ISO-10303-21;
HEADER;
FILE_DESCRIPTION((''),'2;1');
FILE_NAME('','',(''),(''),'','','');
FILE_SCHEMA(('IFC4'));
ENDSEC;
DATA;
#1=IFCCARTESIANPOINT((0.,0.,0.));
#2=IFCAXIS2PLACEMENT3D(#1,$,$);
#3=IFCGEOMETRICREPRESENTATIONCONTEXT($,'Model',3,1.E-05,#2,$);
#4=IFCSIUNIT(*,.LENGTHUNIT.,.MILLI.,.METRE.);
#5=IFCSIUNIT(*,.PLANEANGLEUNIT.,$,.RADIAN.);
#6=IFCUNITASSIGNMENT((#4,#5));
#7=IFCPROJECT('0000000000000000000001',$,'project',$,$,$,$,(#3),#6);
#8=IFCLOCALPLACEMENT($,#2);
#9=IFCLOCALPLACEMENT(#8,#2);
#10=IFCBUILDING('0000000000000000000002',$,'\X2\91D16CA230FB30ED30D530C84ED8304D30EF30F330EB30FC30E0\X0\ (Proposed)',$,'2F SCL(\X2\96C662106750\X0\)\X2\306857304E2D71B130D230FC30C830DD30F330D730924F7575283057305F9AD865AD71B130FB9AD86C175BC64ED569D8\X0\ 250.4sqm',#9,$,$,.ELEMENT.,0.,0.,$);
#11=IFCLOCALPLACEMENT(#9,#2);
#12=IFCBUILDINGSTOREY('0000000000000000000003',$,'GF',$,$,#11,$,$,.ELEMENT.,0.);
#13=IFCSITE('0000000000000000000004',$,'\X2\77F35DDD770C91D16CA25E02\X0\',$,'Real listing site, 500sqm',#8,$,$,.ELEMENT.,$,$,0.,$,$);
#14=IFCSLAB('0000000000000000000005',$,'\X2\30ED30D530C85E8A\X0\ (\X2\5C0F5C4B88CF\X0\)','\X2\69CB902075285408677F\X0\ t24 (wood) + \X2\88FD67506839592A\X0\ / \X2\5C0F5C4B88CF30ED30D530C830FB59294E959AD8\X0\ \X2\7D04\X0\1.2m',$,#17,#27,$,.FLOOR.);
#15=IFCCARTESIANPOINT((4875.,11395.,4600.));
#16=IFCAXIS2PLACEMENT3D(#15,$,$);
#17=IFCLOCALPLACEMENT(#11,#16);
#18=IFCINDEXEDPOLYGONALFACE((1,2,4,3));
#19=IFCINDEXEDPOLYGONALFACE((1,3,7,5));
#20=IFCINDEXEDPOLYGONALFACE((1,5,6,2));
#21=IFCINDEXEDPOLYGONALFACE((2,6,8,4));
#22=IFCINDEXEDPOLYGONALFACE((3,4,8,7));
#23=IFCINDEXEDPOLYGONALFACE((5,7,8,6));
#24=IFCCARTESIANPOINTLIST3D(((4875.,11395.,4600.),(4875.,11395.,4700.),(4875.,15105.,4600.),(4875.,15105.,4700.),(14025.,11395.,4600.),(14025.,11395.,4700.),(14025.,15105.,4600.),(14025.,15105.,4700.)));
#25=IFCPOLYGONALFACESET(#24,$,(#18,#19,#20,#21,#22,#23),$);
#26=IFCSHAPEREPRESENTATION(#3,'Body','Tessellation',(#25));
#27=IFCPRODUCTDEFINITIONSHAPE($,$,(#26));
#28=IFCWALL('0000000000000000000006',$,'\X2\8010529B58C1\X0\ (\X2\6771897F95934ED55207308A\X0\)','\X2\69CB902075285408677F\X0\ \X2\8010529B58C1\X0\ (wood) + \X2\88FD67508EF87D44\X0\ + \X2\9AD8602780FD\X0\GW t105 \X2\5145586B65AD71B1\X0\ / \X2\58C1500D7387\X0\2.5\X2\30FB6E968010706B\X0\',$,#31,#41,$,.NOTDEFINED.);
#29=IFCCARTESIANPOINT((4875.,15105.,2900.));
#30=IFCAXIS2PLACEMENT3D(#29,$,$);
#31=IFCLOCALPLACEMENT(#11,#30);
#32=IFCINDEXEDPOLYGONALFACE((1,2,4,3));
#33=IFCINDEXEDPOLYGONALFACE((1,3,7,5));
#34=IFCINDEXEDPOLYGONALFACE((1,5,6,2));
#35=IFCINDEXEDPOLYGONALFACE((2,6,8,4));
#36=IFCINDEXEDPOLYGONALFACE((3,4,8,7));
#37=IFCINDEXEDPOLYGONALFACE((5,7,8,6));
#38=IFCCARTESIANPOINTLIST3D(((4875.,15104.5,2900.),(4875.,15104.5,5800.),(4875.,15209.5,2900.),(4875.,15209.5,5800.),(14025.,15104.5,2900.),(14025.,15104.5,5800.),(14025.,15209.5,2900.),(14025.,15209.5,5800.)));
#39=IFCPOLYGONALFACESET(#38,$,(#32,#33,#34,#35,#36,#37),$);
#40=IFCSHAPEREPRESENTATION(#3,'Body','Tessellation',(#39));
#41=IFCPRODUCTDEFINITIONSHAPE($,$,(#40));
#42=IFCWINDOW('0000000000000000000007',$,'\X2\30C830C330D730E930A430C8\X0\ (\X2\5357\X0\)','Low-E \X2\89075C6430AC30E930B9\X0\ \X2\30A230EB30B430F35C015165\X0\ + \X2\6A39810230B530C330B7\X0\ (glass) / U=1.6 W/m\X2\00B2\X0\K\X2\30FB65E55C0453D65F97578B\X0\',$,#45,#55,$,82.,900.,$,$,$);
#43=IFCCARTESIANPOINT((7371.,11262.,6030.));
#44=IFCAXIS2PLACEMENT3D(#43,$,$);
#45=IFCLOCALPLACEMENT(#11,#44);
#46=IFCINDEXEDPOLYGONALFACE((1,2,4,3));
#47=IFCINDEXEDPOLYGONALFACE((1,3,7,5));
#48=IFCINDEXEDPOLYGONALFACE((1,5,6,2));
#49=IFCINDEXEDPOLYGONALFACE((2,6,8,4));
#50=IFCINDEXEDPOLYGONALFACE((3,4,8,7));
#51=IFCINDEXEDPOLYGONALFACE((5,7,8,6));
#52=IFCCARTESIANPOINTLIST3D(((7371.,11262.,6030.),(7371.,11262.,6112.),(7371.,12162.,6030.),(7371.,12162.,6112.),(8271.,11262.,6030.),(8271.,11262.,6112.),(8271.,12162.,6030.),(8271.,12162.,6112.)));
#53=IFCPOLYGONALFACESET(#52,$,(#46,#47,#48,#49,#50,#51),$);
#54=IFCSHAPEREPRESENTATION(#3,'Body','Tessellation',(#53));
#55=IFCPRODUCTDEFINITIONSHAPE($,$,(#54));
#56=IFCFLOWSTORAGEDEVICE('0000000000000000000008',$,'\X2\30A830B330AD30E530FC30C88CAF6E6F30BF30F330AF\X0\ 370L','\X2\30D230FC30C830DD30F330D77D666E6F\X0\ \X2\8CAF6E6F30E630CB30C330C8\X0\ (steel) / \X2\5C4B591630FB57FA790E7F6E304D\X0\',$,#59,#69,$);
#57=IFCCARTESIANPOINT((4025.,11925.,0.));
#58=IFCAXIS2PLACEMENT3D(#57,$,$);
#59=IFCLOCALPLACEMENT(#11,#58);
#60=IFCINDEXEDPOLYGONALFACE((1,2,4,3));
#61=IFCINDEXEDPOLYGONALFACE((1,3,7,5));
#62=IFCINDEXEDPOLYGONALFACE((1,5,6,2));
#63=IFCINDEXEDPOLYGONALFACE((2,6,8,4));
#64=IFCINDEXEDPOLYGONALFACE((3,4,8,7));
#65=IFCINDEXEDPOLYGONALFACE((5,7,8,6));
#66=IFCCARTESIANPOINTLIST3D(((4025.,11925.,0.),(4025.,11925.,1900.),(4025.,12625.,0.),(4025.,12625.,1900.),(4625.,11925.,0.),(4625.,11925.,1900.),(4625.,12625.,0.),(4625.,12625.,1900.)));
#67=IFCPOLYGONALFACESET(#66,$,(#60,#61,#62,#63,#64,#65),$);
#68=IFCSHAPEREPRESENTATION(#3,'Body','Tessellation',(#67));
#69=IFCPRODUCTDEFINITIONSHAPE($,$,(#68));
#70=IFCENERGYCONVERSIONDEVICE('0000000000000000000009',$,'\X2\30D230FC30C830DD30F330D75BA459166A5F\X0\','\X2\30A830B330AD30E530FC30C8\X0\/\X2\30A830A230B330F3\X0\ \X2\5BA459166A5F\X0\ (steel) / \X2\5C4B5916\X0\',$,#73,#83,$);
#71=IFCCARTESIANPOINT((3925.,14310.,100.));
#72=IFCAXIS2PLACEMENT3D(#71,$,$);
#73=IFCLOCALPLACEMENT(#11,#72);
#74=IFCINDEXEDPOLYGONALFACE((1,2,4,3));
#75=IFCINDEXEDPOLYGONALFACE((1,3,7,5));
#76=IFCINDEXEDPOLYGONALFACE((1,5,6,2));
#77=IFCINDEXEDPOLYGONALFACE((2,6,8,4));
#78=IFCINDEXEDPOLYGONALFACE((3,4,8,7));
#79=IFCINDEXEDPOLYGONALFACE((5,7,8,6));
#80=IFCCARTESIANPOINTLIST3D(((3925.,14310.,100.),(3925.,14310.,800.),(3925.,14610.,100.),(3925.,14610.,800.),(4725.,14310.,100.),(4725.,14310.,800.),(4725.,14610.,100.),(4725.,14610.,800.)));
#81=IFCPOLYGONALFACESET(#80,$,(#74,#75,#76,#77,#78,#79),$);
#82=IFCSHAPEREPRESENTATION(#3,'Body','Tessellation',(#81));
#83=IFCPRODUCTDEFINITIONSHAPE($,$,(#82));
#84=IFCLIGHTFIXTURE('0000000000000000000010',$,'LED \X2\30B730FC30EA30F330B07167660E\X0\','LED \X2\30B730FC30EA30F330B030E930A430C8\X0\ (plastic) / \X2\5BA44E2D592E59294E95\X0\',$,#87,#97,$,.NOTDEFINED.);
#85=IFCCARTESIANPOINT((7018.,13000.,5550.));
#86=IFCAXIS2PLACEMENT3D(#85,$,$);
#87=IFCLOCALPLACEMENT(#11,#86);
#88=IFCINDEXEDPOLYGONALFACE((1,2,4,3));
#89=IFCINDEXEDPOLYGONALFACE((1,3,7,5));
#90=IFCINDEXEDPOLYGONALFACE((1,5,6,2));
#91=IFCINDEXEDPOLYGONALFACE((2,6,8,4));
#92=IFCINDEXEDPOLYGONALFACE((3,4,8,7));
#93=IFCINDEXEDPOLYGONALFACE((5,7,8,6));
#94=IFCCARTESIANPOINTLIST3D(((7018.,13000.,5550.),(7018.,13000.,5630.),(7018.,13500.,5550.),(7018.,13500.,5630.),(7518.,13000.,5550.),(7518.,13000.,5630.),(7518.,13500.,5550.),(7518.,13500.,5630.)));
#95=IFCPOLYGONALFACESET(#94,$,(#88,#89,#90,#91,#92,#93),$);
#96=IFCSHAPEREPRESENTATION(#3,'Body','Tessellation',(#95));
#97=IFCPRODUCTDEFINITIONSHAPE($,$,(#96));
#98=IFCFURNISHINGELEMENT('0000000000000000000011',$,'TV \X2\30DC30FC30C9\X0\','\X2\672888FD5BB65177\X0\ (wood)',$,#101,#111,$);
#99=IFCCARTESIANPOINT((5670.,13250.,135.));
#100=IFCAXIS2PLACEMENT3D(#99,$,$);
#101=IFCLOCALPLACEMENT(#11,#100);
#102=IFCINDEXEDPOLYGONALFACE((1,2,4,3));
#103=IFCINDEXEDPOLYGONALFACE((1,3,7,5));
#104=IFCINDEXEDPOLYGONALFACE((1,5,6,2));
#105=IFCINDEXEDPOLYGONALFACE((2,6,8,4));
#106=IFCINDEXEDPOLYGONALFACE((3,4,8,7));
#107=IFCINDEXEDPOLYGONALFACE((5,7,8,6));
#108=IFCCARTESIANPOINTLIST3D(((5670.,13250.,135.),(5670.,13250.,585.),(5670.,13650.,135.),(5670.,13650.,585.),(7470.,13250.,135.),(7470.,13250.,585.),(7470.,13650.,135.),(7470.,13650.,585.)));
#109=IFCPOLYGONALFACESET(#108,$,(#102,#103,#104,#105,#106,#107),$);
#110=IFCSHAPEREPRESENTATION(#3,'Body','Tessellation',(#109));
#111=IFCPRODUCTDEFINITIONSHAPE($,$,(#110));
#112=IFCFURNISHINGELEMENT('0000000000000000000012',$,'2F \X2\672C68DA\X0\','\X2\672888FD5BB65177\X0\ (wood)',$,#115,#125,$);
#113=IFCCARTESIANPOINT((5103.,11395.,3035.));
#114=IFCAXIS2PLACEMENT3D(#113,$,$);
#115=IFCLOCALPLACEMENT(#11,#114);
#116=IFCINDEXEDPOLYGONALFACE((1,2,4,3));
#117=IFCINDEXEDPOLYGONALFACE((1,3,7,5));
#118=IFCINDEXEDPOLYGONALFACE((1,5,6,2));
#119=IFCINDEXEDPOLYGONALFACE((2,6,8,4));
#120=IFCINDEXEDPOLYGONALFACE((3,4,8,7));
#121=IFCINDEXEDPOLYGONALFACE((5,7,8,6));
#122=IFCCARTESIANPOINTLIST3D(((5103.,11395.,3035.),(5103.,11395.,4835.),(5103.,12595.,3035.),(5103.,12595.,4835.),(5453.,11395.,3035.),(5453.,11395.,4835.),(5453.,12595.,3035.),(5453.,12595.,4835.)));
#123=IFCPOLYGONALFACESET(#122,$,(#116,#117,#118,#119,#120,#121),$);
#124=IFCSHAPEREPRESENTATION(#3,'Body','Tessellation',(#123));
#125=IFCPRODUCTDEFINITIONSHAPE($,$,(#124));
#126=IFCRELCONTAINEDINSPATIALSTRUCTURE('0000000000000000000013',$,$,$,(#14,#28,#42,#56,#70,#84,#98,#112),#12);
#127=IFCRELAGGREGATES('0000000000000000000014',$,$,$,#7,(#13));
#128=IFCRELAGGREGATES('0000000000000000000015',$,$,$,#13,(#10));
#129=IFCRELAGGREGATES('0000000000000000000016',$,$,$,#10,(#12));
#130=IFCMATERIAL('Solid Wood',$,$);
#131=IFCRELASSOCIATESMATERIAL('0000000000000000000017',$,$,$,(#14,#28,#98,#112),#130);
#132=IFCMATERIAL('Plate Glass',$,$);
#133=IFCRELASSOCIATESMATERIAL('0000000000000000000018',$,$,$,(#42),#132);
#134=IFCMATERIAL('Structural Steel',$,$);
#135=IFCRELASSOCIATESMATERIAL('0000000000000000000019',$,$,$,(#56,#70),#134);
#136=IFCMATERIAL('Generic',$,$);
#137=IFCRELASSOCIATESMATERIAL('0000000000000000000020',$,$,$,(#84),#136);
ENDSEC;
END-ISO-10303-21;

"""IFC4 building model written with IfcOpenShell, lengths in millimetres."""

from ifc_helpers import new_model, si_unit, frame, frame_2d, origin, place, context, project, spatial, rectangle, extrude, material, element, save


model = new_model("IFC4")

# Units and contexts
model_context = context("Model", 3, precision=1e-05, world=origin())
ifc_project = project(units=[si_unit("LENGTHUNIT", "METRE", prefix="MILLI"), si_unit("PLANEANGLEUNIT", "RADIAN")], contexts=[model_context])

# Site, building, storey
site_placement = place(None, origin())
site = spatial("IfcSite", under=ifc_project, at=site_placement, Name="石川県金沢市", ObjectType="Real listing site, 500sqm", CompositionType="ELEMENT", RefElevation=0.0)
building_placement = place(site_placement, origin())
building = spatial("IfcBuilding", under=site, at=building_placement, Name="金沢・ロフト付きワンルーム (Proposed)", ObjectType="2F SCL(集成材)と地中熱ヒートポンプを併用した高断熱・高気密仕様 250.4sqm", CompositionType="ELEMENT", ElevationOfRefHeight=0.0, ElevationOfTerrain=0.0)
storey_placement = place(building_placement, origin())
storey = spatial("IfcBuildingStorey", under=building, at=storey_placement, Name="GF", CompositionType="ELEMENT", Elevation=0.0)

# Shared definitions
ifc_material_1 = material(Name="Solid Wood")

# Slab
slab_placement = place(storey_placement, frame((4875.0, 11395.0, 4600.0)))
element("IfcSlab", 1, at=slab_placement, inside=storey, material=ifc_material_1, Name="ロフト床 (小屋裏)", Description="構造用合板 t24 (wood) + 製材根太 / 小屋裏ロフト・天井高 約1.2m", PredefinedType="FLOOR", context=model_context, shape_type="SweptSolid", body=[
    extrude(rectangle(XDim=9150.0, YDim=3710.0, at=frame_2d((4575.0, 1855.0))), frame((4875.0, 11395.0, 4600.0)), (0.0, 0.0, 1.0), 100.0),
])

# Wall
wall_1_placement = place(storey_placement, frame((4875.0, 15105.0, 2900.0)))
element("IfcWall", 2, at=wall_1_placement, inside=storey, material=ifc_material_1, Name="耐力壁 (東西間仕切り)", Description="構造用合板 耐力壁 (wood) + 製材軸組 + 高性能GW t105 充填断熱 / 壁倍率2.5・準耐火", PredefinedType="NOTDEFINED", context=model_context, shape_type="SweptSolid", body=[
    extrude(rectangle(XDim=9150.0, YDim=105.0, at=frame_2d((4575.0, 52.0))), frame((4875.0, 15105.0, 2900.0)), (0.0, 0.0, 1.0), 2900.0),
])

# Window
ifc_material_2 = material(Name="Plate Glass")
window_placement = place(storey_placement, frame((7371.0, 11262.0, 6030.0)))
element("IfcWindow", 3, at=window_placement, inside=storey, material=ifc_material_2, Name="トップライト (南)", Description="Low-E 複層ガラス アルゴン封入 + 樹脂サッシ (glass) / U=1.6 W/m²K・日射取得型", OverallHeight=82.0, OverallWidth=900.0, context=model_context, shape_type="SweptSolid", body=[
    extrude(rectangle(XDim=900.0, YDim=900.0, at=frame_2d((450.0, 450.0))), frame((7371.0, 11262.0, 6030.0)), (0.0, 0.0, 1.0), 82.0),
])

# Flow storage device
ifc_material_3 = material(Name="Structural Steel")
flow_storage_device_placement = place(storey_placement, frame((4025.0, 11925.0, 0.0)))
element("IfcFlowStorageDevice", 4, at=flow_storage_device_placement, inside=storey, material=ifc_material_3, Name="エコキュート貯湯タンク 370L", Description="ヒートポンプ給湯 貯湯ユニット (steel) / 屋外・基礎置き", context=model_context, shape_type="SweptSolid", body=[
    extrude(rectangle(XDim=600.0, YDim=700.0, at=frame_2d((300.0, 350.0))), frame((4025.0, 11925.0, 0.0)), (0.0, 0.0, 1.0), 1900.0),
])

# Energy conversion device
energy_conversion_device_placement = place(storey_placement, frame((3925.0, 14310.0, 100.0)))
element("IfcEnergyConversionDevice", 5, at=energy_conversion_device_placement, inside=storey, material=ifc_material_3, Name="ヒートポンプ室外機", Description="エコキュート/エアコン 室外機 (steel) / 屋外", context=model_context, shape_type="SweptSolid", body=[
    extrude(rectangle(XDim=800.0, YDim=300.0, at=frame_2d((400.0, 150.0))), frame((3925.0, 14310.0, 100.0)), (0.0, 0.0, 1.0), 700.0),
])

# Light fixture
ifc_material_4 = material(Name="Generic")
light_fixture_placement = place(storey_placement, frame((7018.0, 13000.0, 5550.0)))
element("IfcLightFixture", 6, at=light_fixture_placement, inside=storey, material=ifc_material_4, Name="LED シーリング照明", Description="LED シーリングライト (plastic) / 室中央天井", PredefinedType="NOTDEFINED", context=model_context, shape_type="SweptSolid", body=[
    extrude(rectangle(XDim=500.0, YDim=500.0, at=frame_2d((250.0, 250.0))), frame((7018.0, 13000.0, 5550.0)), (0.0, 0.0, 1.0), 80.0),
])

# Furnishing elements
furnishing_1_placement = place(storey_placement, frame((5670.0, 13250.0, 135.0)))
element("IfcFurnishingElement", 7, at=furnishing_1_placement, inside=storey, material=ifc_material_1, Name="TV ボード", Description="木製家具 (wood)", context=model_context, shape_type="SweptSolid", body=[
    extrude(rectangle(XDim=1800.0, YDim=400.0, at=frame_2d((900.0, 200.0))), frame((5670.0, 13250.0, 135.0)), (0.0, 0.0, 1.0), 450.0),
])
furnishing_2_placement = place(storey_placement, frame((5103.0, 11395.0, 3035.0)))
element("IfcFurnishingElement", 8, at=furnishing_2_placement, inside=storey, material=ifc_material_1, Name="2F 本棚", Description="木製家具 (wood)", context=model_context, shape_type="SweptSolid", body=[
    extrude(rectangle(XDim=350.0, YDim=1200.0, at=frame_2d((175.0, 600.0))), frame((5103.0, 11395.0, 3035.0)), (0.0, 0.0, 1.0), 1800.0),
])

save(model, "model.ifc")
